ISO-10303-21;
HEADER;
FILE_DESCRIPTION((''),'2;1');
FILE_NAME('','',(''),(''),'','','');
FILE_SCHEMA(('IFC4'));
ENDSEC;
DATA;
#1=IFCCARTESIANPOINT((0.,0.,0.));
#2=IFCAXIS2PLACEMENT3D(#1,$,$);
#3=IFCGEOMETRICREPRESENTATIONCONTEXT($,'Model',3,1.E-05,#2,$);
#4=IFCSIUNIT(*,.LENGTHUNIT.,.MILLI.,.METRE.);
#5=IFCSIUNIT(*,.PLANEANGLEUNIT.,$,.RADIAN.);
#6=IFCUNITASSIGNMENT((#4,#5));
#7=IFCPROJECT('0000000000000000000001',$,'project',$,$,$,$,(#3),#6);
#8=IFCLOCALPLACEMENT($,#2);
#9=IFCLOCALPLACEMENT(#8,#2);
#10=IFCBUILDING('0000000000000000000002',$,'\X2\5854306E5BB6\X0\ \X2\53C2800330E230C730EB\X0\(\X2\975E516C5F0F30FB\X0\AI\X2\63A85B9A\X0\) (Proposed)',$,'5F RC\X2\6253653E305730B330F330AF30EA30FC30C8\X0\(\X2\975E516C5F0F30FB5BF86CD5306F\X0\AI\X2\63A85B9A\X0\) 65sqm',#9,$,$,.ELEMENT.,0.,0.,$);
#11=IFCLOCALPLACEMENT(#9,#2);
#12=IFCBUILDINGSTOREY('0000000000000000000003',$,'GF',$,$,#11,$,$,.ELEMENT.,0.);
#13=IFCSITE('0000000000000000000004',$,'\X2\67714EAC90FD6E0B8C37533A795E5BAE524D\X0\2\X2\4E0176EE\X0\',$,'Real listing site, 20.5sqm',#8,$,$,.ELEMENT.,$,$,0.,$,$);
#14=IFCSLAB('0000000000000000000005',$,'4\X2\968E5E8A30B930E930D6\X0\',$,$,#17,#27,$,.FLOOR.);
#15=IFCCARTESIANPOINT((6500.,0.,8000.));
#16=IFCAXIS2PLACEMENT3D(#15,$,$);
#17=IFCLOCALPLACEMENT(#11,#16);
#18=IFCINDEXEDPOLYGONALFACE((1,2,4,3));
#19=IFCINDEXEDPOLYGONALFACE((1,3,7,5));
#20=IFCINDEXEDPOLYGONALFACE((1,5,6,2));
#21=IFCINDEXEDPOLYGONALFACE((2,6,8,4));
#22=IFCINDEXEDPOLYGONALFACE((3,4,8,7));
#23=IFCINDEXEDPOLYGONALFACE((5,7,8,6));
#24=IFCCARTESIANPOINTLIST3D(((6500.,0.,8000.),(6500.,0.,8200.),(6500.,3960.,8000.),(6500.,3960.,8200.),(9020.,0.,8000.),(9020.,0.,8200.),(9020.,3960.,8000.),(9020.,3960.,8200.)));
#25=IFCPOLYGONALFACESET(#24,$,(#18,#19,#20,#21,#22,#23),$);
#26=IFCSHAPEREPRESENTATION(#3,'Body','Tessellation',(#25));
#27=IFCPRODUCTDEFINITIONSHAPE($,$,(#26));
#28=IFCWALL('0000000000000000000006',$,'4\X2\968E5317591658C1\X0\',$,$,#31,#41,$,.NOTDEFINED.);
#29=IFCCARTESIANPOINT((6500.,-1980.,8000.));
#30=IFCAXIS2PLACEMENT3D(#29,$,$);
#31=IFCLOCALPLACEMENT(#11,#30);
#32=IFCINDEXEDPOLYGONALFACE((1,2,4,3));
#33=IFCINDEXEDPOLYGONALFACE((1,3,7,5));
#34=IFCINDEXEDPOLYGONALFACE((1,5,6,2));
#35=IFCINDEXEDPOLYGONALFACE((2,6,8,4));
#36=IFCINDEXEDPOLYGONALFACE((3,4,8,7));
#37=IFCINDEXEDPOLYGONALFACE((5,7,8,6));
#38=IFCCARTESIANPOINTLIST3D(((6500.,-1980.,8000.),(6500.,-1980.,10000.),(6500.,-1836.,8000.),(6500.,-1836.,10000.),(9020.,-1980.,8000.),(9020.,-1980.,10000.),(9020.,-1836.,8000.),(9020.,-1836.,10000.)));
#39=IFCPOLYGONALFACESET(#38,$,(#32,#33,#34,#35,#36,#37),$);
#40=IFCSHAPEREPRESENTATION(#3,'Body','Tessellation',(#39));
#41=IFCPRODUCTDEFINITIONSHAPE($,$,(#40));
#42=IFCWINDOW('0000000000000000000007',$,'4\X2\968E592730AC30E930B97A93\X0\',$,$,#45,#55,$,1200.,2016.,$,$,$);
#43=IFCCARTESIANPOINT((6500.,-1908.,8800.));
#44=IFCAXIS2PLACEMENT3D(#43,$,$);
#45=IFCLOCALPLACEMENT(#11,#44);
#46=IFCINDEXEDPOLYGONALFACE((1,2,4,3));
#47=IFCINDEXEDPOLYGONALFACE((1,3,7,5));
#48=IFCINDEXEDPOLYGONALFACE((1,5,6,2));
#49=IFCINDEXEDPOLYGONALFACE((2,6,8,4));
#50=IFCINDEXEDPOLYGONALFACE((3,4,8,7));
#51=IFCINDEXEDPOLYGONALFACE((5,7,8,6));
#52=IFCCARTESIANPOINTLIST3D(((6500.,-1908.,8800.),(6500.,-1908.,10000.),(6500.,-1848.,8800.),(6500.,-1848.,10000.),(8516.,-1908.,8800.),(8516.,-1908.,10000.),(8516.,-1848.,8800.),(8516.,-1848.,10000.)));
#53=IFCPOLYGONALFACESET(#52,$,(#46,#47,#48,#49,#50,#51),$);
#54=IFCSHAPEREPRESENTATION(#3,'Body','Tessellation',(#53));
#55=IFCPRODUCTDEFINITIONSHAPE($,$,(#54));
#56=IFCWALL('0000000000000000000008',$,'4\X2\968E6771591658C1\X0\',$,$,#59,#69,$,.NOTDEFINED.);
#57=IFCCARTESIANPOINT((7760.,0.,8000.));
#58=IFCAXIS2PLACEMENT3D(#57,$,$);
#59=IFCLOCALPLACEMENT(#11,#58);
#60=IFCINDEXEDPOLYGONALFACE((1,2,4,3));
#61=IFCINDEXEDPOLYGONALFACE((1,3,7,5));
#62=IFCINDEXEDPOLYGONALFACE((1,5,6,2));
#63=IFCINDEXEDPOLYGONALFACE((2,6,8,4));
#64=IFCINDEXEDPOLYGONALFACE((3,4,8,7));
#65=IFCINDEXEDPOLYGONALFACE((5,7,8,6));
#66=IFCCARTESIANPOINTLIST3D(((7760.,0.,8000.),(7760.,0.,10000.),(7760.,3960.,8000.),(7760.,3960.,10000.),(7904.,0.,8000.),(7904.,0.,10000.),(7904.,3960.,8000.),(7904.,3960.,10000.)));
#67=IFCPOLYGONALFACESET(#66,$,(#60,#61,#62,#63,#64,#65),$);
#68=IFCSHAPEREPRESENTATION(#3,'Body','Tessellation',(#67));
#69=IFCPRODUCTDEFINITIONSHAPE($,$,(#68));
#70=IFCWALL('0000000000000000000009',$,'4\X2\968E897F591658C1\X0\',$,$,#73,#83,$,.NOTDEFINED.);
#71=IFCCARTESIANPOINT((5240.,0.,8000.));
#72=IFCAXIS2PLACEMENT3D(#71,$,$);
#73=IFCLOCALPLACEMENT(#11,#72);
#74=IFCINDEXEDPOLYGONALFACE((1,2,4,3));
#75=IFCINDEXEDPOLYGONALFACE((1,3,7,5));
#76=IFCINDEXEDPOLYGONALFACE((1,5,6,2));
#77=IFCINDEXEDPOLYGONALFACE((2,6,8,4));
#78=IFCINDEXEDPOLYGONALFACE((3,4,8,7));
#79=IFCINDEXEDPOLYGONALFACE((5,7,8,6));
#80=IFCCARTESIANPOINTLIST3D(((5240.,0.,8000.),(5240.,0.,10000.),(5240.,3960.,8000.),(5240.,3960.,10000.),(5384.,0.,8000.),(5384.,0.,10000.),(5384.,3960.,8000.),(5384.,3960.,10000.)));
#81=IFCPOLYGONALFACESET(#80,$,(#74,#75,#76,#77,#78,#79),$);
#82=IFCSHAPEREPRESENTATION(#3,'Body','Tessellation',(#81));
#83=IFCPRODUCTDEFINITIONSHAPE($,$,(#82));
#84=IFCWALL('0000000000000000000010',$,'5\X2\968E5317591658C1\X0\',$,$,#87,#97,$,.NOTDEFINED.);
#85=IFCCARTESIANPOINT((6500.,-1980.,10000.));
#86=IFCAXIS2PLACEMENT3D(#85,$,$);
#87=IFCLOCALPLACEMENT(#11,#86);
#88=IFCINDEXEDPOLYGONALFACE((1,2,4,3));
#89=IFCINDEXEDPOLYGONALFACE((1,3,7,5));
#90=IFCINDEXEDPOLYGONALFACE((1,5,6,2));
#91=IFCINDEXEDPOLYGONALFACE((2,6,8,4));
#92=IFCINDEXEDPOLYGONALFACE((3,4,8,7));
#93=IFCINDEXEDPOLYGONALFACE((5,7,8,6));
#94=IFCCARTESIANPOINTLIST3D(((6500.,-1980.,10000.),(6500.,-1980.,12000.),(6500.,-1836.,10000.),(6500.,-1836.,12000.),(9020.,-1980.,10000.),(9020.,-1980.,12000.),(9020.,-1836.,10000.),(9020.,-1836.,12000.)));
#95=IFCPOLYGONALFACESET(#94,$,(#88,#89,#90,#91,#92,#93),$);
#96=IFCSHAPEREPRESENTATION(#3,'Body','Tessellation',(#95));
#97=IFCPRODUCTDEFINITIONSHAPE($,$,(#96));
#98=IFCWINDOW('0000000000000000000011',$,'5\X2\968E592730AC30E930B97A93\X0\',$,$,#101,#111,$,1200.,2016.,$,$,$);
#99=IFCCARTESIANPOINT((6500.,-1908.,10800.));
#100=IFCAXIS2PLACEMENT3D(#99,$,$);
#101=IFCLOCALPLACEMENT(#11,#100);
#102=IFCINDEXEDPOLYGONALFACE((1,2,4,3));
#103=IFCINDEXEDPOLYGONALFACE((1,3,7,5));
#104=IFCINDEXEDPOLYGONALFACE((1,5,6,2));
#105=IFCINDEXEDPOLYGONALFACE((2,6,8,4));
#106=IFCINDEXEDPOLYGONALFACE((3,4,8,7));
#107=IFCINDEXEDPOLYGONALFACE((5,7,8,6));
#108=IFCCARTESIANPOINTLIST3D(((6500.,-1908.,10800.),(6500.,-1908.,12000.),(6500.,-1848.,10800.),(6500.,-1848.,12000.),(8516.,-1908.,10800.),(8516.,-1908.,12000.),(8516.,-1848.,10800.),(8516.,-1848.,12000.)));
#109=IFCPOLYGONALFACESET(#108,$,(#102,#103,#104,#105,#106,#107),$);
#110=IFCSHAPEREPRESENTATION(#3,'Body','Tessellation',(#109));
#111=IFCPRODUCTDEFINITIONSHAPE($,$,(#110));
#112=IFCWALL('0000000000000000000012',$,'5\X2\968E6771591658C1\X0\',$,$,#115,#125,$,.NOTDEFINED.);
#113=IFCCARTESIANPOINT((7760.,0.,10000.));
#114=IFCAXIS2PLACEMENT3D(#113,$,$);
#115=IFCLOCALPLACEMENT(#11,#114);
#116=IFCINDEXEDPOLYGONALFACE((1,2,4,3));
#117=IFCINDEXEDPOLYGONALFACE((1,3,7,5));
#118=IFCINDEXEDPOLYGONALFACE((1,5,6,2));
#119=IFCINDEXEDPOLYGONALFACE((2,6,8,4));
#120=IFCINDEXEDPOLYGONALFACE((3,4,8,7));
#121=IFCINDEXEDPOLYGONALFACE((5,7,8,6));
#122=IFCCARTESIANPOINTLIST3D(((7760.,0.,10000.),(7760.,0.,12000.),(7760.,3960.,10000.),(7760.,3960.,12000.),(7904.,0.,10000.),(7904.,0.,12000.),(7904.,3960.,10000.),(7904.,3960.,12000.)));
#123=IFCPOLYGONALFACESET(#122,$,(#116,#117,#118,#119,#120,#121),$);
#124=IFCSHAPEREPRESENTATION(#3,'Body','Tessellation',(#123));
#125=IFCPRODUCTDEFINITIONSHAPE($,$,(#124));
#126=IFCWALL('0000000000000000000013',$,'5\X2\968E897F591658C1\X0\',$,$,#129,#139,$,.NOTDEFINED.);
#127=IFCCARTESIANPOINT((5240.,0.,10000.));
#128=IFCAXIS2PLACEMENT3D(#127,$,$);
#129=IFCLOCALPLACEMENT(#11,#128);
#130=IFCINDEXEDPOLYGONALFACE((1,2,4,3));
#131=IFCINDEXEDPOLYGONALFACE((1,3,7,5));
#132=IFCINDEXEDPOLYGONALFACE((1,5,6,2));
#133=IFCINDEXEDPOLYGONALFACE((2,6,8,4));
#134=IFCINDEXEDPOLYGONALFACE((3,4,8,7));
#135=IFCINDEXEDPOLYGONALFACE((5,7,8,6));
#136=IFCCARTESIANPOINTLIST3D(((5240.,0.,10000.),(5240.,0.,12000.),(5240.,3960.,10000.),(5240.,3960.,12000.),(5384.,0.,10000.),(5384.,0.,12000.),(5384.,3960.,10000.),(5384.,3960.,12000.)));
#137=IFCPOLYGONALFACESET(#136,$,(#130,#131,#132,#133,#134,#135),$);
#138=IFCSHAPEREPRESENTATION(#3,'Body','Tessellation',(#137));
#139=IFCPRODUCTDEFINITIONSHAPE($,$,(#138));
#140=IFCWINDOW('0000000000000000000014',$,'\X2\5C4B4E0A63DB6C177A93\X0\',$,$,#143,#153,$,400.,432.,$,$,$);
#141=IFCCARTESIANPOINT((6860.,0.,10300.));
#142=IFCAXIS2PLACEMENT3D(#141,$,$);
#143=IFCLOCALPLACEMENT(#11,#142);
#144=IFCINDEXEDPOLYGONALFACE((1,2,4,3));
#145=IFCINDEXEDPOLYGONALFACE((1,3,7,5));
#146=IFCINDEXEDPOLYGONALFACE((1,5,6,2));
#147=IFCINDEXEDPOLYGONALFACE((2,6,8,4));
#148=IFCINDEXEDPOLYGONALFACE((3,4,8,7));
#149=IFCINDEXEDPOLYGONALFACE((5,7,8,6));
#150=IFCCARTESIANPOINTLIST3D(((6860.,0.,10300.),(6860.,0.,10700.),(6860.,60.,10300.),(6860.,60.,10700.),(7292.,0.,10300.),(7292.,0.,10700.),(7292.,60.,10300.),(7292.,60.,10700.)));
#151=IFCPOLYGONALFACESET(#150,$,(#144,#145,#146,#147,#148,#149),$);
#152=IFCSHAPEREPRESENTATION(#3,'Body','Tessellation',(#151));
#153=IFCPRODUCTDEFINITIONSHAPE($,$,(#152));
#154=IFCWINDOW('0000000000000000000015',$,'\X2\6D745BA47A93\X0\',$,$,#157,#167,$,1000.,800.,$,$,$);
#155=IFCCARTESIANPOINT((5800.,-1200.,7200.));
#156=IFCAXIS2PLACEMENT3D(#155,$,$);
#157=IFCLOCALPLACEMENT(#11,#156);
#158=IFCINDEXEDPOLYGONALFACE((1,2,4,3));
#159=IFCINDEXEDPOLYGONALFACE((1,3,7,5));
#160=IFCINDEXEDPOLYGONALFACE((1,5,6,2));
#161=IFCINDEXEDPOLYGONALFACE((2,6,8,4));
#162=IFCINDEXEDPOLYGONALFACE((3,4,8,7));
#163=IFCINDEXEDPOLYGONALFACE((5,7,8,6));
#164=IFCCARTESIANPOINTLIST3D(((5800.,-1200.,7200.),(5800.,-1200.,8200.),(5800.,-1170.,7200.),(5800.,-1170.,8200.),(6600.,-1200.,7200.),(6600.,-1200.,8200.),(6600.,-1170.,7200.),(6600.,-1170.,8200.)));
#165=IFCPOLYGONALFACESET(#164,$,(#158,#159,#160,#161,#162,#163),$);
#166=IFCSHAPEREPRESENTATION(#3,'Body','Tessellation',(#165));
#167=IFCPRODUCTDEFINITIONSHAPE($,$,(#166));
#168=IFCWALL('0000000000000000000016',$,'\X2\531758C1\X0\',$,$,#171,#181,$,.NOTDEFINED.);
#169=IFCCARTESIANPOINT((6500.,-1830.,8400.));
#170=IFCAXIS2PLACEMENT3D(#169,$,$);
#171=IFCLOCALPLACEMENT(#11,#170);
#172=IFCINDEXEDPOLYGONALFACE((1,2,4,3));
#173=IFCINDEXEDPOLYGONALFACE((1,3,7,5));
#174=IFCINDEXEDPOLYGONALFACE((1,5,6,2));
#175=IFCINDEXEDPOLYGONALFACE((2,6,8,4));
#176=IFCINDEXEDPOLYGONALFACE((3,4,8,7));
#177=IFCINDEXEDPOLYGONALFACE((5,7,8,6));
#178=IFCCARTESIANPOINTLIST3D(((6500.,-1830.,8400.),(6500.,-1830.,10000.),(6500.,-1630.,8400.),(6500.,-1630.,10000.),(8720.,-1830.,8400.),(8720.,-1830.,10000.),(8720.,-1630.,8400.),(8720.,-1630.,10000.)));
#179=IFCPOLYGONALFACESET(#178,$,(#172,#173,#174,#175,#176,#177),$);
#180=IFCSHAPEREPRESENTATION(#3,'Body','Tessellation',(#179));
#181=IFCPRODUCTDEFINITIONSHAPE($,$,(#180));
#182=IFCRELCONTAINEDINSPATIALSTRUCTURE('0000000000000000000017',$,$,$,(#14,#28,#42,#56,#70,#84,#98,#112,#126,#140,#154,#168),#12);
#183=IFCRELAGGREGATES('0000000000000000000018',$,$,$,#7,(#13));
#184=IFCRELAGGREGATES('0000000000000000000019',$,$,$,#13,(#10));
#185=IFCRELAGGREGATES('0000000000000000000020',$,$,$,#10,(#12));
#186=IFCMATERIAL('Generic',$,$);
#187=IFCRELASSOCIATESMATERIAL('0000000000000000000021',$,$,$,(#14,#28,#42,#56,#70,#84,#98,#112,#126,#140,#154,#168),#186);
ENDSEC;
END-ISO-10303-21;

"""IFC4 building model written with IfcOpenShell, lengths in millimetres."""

from ifc_helpers import new_model, si_unit, frame, frame_2d, origin, place, context, project, spatial, rectangle, extrude, material, element, fill, save


model = new_model("IFC4")

# Units and contexts
model_context = context("Model", 3, precision=1e-05, world=origin())
ifc_project = project(units=[si_unit("LENGTHUNIT", "METRE", prefix="MILLI"), si_unit("PLANEANGLEUNIT", "RADIAN")], contexts=[model_context])

# Site, building, storey
site_placement = place(None, origin())
site = spatial("IfcSite", under=ifc_project, at=site_placement, Name="東京都渋谷区神宮前2丁目", ObjectType="Real listing site, 20.5sqm", CompositionType="ELEMENT", RefElevation=0.0)
building_placement = place(site_placement, origin())
building = spatial("IfcBuilding", under=site, at=building_placement, Name="塔の家 参考モデル(非公式・AI推定) (Proposed)", ObjectType="5F RC打放しコンクリート(非公式・寸法はAI推定) 65sqm", CompositionType="ELEMENT", ElevationOfRefHeight=0.0, ElevationOfTerrain=0.0)
storey_placement = place(building_placement, origin())
storey = spatial("IfcBuildingStorey", under=building, at=storey_placement, Name="GF", CompositionType="ELEMENT", Elevation=0.0)

# Slab
ifc_material = material(Name="Generic")
slab_placement = place(storey_placement, frame((6500.0, 0.0, 8000.0)))
element("IfcSlab", 1, at=slab_placement, inside=storey, material=ifc_material, Name="4階床スラブ", PredefinedType="FLOOR", context=model_context, shape_type="SweptSolid", body=[
    extrude(rectangle(XDim=2520.0, YDim=3960.0, at=frame_2d((1260.0, 1980.0))), frame((6500.0, 0.0, 8000.0)), (0.0, 0.0, 1.0), 200.0),
])

# Wall, opening, window
wall_1_placement = place(storey_placement, frame((6500.0, -1980.0, 8000.0)))
wall_1 = element("IfcWall", 2, at=wall_1_placement, inside=storey, material=ifc_material, Name="4階北外壁", PredefinedType="NOTDEFINED", context=model_context, shape_type="SweptSolid", body=[
    extrude(rectangle(XDim=2520.0, YDim=144.0, at=frame_2d((1260.0, 72.0))), frame((6500.0, -1980.0, 8000.0)), (0.0, 0.0, 1.0), 2000.0),
])
opening_1_placement = place(storey_placement, frame((6500.0, -1908.0, 8800.0)))
opening_1 = element("IfcOpeningElement", 3, at=opening_1_placement, cuts=wall_1, PredefinedType="NOTDEFINED", context=model_context, shape_type="SweptSolid", body=[
    extrude(rectangle(XDim=2016.0, YDim=60.0, at=frame_2d((1008.0, 30.0))), frame((6500.0, -1908.0, 8800.0)), (0.0, 0.0, 1.0), 1200.0),
])
window_1_placement = place(storey_placement, frame((6500.0, -1908.0, 8800.0)))
window_1 = element("IfcWindow", 4, at=window_1_placement, inside=storey, material=ifc_material, Name="4階大ガラス窓", OverallHeight=1200.0, OverallWidth=2016.0, context=model_context, shape_type="SweptSolid", body=[
    extrude(rectangle(XDim=2016.0, YDim=60.0, at=frame_2d((1008.0, 30.0))), frame((6500.0, -1908.0, 8800.0)), (0.0, 0.0, 1.0), 1200.0),
])
fill(opening_1, window_1)

# Walls
wall_2_placement = place(storey_placement, frame((7760.0, 0.0, 8000.0)))
element("IfcWall", 5, at=wall_2_placement, inside=storey, material=ifc_material, Name="4階東外壁", PredefinedType="NOTDEFINED", context=model_context, shape_type="SweptSolid", body=[
    extrude(rectangle(XDim=144.0, YDim=3960.0, at=frame_2d((72.0, 1980.0))), frame((7760.0, 0.0, 8000.0)), (0.0, 0.0, 1.0), 2000.0),
])
wall_3_placement = place(storey_placement, frame((5240.0, 0.0, 8000.0)))
element("IfcWall", 6, at=wall_3_placement, inside=storey, material=ifc_material, Name="4階西外壁", PredefinedType="NOTDEFINED", context=model_context, shape_type="SweptSolid", body=[
    extrude(rectangle(XDim=144.0, YDim=3960.0, at=frame_2d((72.0, 1980.0))), frame((5240.0, 0.0, 8000.0)), (0.0, 0.0, 1.0), 2000.0),
])

# Wall, opening, window
wall_4_placement = place(storey_placement, frame((6500.0, -1980.0, 10000.0)))
wall_4 = element("IfcWall", 7, at=wall_4_placement, inside=storey, material=ifc_material, Name="5階北外壁", PredefinedType="NOTDEFINED", context=model_context, shape_type="SweptSolid", body=[
    extrude(rectangle(XDim=2520.0, YDim=144.0, at=frame_2d((1260.0, 72.0))), frame((6500.0, -1980.0, 10000.0)), (0.0, 0.0, 1.0), 2000.0),
])
opening_2_placement = place(storey_placement, frame((6500.0, -1908.0, 10800.0)))
opening_2 = element("IfcOpeningElement", 8, at=opening_2_placement, cuts=wall_4, PredefinedType="NOTDEFINED", context=model_context, shape_type="SweptSolid", body=[
    extrude(rectangle(XDim=2016.0, YDim=60.0, at=frame_2d((1008.0, 30.0))), frame((6500.0, -1908.0, 10800.0)), (0.0, 0.0, 1.0), 1200.0),
])
window_2_placement = place(storey_placement, frame((6500.0, -1908.0, 10800.0)))
window_2 = element("IfcWindow", 9, at=window_2_placement, inside=storey, material=ifc_material, Name="5階大ガラス窓", OverallHeight=1200.0, OverallWidth=2016.0, context=model_context, shape_type="SweptSolid", body=[
    extrude(rectangle(XDim=2016.0, YDim=60.0, at=frame_2d((1008.0, 30.0))), frame((6500.0, -1908.0, 10800.0)), (0.0, 0.0, 1.0), 1200.0),
])
fill(opening_2, window_2)

# Walls
wall_5_placement = place(storey_placement, frame((7760.0, 0.0, 10000.0)))
element("IfcWall", 10, at=wall_5_placement, inside=storey, material=ifc_material, Name="5階東外壁", PredefinedType="NOTDEFINED", context=model_context, shape_type="SweptSolid", body=[
    extrude(rectangle(XDim=144.0, YDim=3960.0, at=frame_2d((72.0, 1980.0))), frame((7760.0, 0.0, 10000.0)), (0.0, 0.0, 1.0), 2000.0),
])
wall_6_placement = place(storey_placement, frame((5240.0, 0.0, 10000.0)))
element("IfcWall", 11, at=wall_6_placement, inside=storey, material=ifc_material, Name="5階西外壁", PredefinedType="NOTDEFINED", context=model_context, shape_type="SweptSolid", body=[
    extrude(rectangle(XDim=144.0, YDim=3960.0, at=frame_2d((72.0, 1980.0))), frame((5240.0, 0.0, 10000.0)), (0.0, 0.0, 1.0), 2000.0),
])

# Windows
window_3_placement = place(storey_placement, frame((6860.0, 0.0, 10300.0)))
element("IfcWindow", 12, at=window_3_placement, inside=storey, material=ifc_material, Name="屋上換気窓", OverallHeight=400.0, OverallWidth=432.0, context=model_context, shape_type="SweptSolid", body=[
    extrude(rectangle(XDim=432.0, YDim=60.0, at=frame_2d((216.0, 30.0))), frame((6860.0, 0.0, 10300.0)), (0.0, 0.0, 1.0), 400.0),
])
window_4_placement = place(storey_placement, frame((5800.0, -1200.0, 7200.0)))
element("IfcWindow", 13, at=window_4_placement, inside=storey, material=ifc_material, Name="浴室窓", OverallHeight=1000.0, OverallWidth=800.0, context=model_context, shape_type="SweptSolid", body=[
    extrude(rectangle(XDim=800.0, YDim=30.0, at=frame_2d((400.0, 15.0))), frame((5800.0, -1200.0, 7200.0)), (0.0, 0.0, 1.0), 1000.0),
])

# Wall
wall_7_placement = place(storey_placement, frame((6500.0, -1830.0, 8400.0)))
element("IfcWall", 14, at=wall_7_placement, inside=storey, material=ifc_material, Name="北壁", PredefinedType="NOTDEFINED", context=model_context, shape_type="SweptSolid", body=[
    extrude(rectangle(XDim=2220.0, YDim=200.0, at=frame_2d((1110.0, 100.0))), frame((6500.0, -1830.0, 8400.0)), (0.0, 0.0, 1.0), 1600.0),
])

save(model, "model.ifc")
